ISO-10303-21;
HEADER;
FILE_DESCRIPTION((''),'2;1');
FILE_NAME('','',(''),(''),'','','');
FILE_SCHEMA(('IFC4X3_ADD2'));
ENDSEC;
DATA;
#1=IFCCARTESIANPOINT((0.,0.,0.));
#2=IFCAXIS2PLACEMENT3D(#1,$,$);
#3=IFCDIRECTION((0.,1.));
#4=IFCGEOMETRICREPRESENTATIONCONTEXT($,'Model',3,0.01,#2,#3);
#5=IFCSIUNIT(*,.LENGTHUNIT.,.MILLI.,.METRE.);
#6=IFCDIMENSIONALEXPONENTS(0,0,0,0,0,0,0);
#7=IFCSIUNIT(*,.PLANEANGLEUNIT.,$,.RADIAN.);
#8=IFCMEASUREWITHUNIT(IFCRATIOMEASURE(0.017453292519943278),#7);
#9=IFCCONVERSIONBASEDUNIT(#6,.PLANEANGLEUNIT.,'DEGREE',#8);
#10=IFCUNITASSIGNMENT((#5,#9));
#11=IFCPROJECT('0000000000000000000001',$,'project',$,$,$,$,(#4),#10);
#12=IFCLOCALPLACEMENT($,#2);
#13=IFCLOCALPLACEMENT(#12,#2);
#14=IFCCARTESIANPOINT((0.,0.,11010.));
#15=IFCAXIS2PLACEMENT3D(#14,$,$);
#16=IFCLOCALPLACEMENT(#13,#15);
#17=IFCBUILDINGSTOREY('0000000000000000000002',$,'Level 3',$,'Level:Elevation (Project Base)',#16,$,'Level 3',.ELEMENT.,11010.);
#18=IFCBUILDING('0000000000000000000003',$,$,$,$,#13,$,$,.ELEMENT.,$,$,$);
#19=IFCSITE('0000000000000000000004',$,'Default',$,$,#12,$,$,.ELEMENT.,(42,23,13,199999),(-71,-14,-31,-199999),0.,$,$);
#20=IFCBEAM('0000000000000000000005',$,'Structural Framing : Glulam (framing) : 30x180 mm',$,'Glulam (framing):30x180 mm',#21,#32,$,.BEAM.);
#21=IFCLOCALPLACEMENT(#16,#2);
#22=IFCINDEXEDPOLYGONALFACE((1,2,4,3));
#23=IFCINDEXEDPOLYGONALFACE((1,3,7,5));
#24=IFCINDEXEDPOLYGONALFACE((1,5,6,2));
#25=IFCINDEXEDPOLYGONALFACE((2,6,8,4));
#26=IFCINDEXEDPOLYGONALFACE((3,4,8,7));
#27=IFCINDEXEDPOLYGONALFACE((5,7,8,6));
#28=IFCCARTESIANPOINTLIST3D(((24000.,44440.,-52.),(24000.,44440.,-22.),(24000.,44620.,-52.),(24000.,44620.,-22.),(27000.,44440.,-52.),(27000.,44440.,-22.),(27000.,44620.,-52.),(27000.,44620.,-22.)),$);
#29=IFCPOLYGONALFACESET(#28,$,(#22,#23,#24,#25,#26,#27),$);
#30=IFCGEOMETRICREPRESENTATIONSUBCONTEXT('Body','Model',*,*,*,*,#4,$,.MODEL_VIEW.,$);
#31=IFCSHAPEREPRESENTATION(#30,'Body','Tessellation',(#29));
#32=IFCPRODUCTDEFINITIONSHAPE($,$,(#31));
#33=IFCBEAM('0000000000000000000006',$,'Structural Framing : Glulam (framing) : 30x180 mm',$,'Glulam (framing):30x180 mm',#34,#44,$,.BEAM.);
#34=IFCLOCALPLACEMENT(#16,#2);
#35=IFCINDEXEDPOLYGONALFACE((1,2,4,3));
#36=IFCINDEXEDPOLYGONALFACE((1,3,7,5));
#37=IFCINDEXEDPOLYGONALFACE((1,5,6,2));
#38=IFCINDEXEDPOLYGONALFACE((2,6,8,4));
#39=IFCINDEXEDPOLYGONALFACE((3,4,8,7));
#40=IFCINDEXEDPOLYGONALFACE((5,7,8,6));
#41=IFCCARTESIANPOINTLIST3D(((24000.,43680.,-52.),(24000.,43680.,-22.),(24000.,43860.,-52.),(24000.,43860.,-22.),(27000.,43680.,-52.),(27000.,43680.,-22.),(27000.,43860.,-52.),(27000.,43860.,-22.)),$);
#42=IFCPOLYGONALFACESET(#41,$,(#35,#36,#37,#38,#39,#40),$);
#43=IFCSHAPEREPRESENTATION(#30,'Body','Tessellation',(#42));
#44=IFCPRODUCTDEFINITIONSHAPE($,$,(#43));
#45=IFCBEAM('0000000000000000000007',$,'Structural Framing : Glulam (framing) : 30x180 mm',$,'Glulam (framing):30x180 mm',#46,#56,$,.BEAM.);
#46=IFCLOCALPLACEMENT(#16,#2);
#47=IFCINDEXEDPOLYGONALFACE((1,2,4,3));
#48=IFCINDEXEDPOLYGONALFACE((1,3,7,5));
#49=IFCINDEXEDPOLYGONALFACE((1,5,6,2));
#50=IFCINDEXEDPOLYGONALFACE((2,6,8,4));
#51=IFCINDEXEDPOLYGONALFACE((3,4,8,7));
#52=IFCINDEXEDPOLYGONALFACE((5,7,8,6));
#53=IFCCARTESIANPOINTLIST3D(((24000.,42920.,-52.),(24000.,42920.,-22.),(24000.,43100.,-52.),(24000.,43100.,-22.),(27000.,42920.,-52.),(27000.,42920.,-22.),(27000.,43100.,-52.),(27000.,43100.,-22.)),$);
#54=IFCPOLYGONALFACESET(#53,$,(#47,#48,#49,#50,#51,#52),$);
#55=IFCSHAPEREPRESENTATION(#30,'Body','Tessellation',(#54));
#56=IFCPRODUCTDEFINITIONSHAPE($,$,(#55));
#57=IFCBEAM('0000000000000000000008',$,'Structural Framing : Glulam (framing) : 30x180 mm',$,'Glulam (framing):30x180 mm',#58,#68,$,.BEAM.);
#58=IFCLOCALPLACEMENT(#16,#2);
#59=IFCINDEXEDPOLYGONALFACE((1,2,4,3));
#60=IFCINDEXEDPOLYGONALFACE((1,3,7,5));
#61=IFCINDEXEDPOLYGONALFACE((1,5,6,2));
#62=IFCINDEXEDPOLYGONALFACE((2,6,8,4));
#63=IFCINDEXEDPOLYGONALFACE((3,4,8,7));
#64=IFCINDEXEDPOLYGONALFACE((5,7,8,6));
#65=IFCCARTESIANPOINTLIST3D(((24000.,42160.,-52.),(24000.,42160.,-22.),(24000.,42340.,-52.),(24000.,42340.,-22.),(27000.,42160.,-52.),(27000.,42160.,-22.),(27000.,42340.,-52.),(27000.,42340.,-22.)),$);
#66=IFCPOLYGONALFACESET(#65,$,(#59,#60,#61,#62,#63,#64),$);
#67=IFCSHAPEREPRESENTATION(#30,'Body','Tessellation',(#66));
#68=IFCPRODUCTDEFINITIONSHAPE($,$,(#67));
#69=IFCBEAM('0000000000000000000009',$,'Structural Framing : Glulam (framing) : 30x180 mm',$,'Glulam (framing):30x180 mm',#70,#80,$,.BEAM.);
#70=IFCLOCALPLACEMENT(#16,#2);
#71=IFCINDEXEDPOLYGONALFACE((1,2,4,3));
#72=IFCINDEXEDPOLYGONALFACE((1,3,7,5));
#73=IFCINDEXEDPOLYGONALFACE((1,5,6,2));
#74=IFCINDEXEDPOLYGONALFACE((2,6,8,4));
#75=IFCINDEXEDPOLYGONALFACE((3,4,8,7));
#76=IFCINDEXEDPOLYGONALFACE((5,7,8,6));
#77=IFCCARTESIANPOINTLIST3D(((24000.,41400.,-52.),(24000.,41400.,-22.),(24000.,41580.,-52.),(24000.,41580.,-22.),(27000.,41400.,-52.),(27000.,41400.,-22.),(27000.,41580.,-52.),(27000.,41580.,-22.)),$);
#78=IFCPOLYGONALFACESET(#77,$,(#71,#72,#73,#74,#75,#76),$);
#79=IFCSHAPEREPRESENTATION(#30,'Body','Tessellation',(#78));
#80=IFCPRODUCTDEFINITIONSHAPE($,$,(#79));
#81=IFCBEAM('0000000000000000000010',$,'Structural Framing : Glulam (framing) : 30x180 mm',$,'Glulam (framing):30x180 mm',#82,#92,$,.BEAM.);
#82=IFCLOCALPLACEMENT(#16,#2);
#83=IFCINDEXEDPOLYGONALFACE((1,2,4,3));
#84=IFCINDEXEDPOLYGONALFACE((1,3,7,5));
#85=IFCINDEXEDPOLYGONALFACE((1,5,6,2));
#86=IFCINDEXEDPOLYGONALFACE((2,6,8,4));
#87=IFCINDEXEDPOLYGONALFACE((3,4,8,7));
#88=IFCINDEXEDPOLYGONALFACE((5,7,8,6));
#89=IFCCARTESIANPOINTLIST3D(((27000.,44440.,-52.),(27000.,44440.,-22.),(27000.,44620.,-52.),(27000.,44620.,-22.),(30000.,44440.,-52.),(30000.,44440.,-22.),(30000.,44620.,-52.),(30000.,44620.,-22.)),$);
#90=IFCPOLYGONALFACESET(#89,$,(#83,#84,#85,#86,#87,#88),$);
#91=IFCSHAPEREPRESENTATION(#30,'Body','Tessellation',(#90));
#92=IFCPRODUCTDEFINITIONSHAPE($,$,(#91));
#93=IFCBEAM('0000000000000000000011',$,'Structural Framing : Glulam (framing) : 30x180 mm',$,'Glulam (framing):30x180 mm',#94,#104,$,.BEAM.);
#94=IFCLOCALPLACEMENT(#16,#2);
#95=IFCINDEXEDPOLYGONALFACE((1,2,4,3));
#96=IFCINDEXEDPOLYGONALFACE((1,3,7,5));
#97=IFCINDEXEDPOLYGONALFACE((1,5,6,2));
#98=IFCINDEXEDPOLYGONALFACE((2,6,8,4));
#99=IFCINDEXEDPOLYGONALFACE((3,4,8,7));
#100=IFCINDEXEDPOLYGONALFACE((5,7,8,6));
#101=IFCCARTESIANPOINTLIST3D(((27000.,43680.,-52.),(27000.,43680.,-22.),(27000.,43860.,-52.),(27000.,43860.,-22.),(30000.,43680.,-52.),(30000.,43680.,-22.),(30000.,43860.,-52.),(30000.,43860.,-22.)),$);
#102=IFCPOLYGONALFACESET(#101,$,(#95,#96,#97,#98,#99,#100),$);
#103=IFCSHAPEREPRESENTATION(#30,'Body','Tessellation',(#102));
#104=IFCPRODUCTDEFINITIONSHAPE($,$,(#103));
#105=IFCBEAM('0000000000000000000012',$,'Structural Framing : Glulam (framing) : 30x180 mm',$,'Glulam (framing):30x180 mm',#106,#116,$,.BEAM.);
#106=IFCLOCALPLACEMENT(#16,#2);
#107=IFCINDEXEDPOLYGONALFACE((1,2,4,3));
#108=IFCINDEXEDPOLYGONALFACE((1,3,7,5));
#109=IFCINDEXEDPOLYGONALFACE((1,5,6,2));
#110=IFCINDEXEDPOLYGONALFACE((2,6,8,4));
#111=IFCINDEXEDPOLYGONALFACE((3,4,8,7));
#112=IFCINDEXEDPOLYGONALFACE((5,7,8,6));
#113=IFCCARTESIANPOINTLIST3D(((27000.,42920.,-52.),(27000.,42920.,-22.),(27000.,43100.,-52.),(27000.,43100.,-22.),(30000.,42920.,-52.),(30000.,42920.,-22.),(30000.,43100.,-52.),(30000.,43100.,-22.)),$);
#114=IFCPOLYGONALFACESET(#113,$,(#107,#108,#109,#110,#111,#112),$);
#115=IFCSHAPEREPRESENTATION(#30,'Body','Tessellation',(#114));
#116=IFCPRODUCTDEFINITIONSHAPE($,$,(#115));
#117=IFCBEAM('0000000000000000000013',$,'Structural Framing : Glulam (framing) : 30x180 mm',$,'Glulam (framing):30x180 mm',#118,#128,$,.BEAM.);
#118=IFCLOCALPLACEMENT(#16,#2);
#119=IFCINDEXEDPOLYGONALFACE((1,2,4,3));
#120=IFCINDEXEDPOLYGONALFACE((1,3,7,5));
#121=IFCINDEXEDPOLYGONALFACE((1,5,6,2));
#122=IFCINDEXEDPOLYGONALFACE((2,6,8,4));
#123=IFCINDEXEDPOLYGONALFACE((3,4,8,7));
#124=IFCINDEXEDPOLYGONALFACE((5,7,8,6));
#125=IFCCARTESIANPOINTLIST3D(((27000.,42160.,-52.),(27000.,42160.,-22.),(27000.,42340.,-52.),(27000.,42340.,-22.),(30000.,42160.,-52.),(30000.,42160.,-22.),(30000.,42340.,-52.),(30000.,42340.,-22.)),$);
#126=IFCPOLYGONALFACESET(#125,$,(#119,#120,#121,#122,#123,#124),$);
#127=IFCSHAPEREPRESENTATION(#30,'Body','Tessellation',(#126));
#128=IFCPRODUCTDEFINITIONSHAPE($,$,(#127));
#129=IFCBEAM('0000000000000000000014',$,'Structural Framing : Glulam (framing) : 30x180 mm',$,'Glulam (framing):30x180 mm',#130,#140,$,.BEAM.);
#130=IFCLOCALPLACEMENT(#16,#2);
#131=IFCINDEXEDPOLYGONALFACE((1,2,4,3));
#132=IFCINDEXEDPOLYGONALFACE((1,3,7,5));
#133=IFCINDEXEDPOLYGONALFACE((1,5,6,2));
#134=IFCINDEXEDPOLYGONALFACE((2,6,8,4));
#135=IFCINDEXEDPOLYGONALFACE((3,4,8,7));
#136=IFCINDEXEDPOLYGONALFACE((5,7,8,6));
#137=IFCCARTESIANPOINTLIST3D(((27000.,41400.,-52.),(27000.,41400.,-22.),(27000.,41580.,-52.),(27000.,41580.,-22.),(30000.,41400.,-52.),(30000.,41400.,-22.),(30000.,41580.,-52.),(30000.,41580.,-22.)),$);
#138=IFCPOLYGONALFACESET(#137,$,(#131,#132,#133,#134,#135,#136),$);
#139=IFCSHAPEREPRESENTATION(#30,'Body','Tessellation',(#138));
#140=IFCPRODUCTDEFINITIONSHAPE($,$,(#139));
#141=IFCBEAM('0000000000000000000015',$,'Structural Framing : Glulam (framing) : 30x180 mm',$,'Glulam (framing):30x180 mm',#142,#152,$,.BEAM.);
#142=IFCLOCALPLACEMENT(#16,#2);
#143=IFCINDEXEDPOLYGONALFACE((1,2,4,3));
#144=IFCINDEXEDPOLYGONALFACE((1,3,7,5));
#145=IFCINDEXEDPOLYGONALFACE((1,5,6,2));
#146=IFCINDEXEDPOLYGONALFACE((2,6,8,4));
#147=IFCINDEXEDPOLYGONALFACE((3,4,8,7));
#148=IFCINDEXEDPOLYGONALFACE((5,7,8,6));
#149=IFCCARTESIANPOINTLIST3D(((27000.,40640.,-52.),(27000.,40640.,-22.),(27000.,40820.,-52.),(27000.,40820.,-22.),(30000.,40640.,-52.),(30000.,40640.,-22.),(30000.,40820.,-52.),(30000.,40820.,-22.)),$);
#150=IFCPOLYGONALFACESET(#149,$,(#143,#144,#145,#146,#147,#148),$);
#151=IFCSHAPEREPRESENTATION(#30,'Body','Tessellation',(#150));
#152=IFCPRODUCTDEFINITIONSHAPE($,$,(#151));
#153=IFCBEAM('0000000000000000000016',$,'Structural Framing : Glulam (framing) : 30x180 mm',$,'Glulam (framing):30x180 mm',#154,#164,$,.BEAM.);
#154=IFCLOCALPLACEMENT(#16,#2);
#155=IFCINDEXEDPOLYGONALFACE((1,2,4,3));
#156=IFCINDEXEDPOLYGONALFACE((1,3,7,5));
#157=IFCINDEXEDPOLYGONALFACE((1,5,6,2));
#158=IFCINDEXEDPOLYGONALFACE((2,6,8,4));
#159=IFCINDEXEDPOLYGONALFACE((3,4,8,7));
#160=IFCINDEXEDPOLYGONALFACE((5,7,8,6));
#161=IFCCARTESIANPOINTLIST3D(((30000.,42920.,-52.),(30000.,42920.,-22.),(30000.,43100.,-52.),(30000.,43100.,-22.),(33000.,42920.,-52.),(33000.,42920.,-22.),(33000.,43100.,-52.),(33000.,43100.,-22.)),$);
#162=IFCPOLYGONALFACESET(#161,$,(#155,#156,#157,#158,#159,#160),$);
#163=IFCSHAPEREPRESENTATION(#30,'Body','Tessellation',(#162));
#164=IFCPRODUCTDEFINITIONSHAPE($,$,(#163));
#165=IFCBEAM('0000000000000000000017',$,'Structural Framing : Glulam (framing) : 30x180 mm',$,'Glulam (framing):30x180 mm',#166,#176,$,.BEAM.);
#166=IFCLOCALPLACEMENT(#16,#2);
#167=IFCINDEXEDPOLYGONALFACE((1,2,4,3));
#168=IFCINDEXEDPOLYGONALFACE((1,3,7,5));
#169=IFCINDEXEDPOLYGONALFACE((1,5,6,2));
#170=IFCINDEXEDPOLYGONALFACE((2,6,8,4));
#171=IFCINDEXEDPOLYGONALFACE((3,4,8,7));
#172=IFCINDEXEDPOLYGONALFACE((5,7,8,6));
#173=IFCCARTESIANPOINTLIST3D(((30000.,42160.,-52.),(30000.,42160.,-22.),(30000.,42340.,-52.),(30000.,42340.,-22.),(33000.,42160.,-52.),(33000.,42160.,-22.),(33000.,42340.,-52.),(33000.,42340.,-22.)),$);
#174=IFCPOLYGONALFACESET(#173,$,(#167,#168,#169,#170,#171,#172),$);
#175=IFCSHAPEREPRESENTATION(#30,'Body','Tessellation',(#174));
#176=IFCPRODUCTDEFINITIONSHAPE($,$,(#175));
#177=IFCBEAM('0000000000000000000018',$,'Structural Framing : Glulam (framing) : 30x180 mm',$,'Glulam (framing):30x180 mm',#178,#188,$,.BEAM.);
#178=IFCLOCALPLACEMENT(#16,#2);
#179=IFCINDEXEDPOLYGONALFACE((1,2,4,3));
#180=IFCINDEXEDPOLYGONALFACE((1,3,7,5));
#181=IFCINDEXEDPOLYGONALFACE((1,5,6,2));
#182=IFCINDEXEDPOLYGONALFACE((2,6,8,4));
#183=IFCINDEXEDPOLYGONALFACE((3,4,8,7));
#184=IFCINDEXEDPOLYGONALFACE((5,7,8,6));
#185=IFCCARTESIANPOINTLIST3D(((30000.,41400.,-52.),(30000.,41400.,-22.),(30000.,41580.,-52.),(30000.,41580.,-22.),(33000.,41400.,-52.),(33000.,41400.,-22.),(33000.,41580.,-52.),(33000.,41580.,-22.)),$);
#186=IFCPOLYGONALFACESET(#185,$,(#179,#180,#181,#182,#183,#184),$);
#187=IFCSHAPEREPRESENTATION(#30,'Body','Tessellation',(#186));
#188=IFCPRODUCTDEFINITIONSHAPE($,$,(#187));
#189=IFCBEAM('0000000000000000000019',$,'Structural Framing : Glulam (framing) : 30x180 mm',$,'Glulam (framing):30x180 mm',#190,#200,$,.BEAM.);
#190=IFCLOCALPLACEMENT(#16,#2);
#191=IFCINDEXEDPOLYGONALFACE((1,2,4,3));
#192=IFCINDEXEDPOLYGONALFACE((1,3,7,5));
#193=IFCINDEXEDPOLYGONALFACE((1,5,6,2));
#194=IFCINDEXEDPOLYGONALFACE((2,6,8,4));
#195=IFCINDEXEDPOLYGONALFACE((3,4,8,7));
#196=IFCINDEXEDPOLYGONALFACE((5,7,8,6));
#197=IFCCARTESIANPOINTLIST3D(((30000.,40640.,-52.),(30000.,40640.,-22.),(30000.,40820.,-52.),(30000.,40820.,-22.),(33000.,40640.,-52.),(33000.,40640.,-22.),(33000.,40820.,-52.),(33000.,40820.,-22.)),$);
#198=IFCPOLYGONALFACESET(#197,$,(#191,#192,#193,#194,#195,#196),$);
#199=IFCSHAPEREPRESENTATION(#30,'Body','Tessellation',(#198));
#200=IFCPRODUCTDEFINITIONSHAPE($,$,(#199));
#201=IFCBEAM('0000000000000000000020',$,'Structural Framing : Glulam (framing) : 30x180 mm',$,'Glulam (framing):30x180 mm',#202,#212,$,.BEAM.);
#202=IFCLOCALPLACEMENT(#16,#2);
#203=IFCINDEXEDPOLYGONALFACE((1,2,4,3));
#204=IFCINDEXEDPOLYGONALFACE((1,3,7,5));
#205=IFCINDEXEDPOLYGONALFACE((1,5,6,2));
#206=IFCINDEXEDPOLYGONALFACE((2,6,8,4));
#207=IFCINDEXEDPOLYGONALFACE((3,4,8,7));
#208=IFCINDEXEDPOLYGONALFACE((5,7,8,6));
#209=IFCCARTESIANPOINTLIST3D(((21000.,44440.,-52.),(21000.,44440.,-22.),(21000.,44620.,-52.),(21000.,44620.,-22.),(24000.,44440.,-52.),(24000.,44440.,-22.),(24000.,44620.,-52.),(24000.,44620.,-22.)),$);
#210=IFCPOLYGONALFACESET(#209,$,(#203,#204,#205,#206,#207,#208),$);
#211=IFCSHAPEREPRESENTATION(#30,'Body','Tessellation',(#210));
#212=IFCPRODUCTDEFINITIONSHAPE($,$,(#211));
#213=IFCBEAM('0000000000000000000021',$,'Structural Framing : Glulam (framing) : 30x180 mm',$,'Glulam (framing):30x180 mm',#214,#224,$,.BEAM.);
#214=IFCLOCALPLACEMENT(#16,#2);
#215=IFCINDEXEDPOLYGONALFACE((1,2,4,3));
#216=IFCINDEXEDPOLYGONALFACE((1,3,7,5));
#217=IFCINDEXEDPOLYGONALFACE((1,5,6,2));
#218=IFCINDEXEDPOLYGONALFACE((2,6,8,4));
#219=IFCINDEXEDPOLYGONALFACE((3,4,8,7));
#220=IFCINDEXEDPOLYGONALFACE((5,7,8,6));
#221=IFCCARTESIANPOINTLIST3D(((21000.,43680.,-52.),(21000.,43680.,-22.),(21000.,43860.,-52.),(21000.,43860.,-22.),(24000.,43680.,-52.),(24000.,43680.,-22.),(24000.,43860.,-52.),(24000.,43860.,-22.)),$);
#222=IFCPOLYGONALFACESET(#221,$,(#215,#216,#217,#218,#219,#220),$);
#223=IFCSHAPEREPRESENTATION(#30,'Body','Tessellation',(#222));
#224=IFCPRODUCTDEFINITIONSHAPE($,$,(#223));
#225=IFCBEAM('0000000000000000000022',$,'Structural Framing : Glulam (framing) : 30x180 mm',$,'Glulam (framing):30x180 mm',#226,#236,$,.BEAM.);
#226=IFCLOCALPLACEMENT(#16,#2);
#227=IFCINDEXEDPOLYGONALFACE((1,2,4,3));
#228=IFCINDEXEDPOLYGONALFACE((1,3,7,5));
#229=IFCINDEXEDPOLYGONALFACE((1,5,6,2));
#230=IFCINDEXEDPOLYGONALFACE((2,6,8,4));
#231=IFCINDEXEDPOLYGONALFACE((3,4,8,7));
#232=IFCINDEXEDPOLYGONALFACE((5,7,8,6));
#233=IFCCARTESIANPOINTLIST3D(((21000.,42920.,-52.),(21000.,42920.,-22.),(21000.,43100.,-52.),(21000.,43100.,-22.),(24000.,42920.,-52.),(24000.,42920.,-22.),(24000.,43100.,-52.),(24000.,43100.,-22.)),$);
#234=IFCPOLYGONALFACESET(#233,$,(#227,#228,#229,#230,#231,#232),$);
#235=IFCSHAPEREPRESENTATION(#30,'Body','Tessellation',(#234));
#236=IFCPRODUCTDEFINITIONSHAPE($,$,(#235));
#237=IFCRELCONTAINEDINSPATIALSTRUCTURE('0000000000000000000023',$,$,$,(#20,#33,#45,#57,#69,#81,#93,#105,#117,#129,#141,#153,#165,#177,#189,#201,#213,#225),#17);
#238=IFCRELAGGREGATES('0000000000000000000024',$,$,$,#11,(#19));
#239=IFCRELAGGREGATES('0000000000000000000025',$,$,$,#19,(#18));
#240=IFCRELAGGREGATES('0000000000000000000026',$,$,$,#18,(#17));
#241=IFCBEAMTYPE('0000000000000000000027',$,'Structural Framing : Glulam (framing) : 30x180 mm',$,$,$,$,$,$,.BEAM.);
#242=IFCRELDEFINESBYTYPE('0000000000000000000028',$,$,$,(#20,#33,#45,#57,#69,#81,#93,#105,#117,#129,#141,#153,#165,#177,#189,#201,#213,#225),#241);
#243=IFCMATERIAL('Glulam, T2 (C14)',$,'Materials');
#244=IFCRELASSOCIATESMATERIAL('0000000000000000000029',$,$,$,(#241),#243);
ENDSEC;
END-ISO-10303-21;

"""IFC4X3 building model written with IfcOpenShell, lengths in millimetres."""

from ifc_helpers import new_model, entity, si_unit, converted_unit, direction, frame, origin, origin_2d_with_axis, place, context, subcontext, project, spatial, rectangle, extrude, source, transform, mapped, material, material_profile, profile_set, type_object, type_shapes, element, save


model = new_model("IFC4X3")

# Units and contexts
model_context = context("Model", 3, precision=0.01, world=origin(), true_north=direction((0.0, 1.0)))
body_context = subcontext(model_context, "Body", "Model", "MODEL_VIEW")
ifc_project = project(units=[si_unit("LENGTHUNIT", "METRE", prefix="MILLI"), converted_unit("PLANEANGLEUNIT", "DEGREE", entity("IfcRatioMeasure", 0.017453292519943278), si_unit("PLANEANGLEUNIT", "RADIAN"), dimensions=[0, 0, 0, 0, 0, 0, 0])], contexts=[model_context])

# Site, building, storey
site_placement = place(None, origin())
site = spatial("IfcSite", under=ifc_project, at=site_placement, Name="Default", CompositionType="ELEMENT", RefLatitude=(42, 23, 13, 199999), RefLongitude=(-71, -14, -31, -199999), RefElevation=0.0)
building_placement = place(site_placement, origin())
building = spatial("IfcBuilding", under=site, at=building_placement, CompositionType="ELEMENT")
storey_placement = place(building_placement, frame((0.0, 0.0, 11010.0)))
storey = spatial("IfcBuildingStorey", under=building, at=storey_placement, Name="Level 3", ObjectType="Level:Elevation (Project Base)", LongName="Level 3", CompositionType="ELEMENT", Elevation=11010.0)

# Beams
ifc_material_1 = material(Name="Glulam, T2 (C14)", Category="Materials")
ifc_material_profile_1 = material_profile(ifc_material_1, rectangle(XDim=30.0, YDim=180.0, at=origin_2d_with_axis()), Name="30x180 mm")
ifc_profile_set_1 = profile_set([ifc_material_profile_1], Name="30x180 mm")
beam_type_1 = type_object("IfcBeamType", Name="Structural Framing : Glulam (framing) : 30x180 mm", PredefinedType="BEAM", material=ifc_profile_set_1)
shared_shape_1 = source(origin(), body_context, "Body", "SweptSolid", [
    extrude(rectangle(XDim=30.0, YDim=180.0, at=origin_2d_with_axis()), frame((500.0, 0.0, 0.0), z_axis=(1.0, 0.0, 0.0), x_axis=(0.0, 0.0, -1.0)), (0.0, 0.0, 1.0), 3000.0),
])
type_shapes(beam_type_1, [shared_shape_1])
for number, where, name in (
    (1, (23500.0, 44530.0, -37.0), "Structural Framing : Glulam (framing) : 30x180 mm"),
    (2, (23500.0, 43770.0, -37.0), "Structural Framing : Glulam (framing) : 30x180 mm"),
    (3, (23500.0, 43010.0, -37.0), "Structural Framing : Glulam (framing) : 30x180 mm"),
    (4, (23500.0, 42250.0, -37.0), "Structural Framing : Glulam (framing) : 30x180 mm"),
    (5, (23500.0, 41490.0, -37.0), "Structural Framing : Glulam (framing) : 30x180 mm"),
    (6, (26500.0, 44530.0, -37.0), "Structural Framing : Glulam (framing) : 30x180 mm"),
    (7, (26500.0, 43770.0, -37.0), "Structural Framing : Glulam (framing) : 30x180 mm"),
    (8, (26500.0, 43010.0, -37.0), "Structural Framing : Glulam (framing) : 30x180 mm"),
    (9, (26500.0, 42250.0, -37.0), "Structural Framing : Glulam (framing) : 30x180 mm"),
    (10, (26500.0, 41490.0, -37.0), "Structural Framing : Glulam (framing) : 30x180 mm"),
    (11, (26500.0, 40730.0, -37.0), "Structural Framing : Glulam (framing) : 30x180 mm"),
    (12, (29500.0, 43010.0, -37.0), "Structural Framing : Glulam (framing) : 30x180 mm"),
    (13, (29500.0, 42250.0, -37.0), "Structural Framing : Glulam (framing) : 30x180 mm"),
    (14, (29500.0, 41490.0, -37.0), "Structural Framing : Glulam (framing) : 30x180 mm"),
    (15, (29500.0, 40730.0, -37.0), "Structural Framing : Glulam (framing) : 30x180 mm"),
    (16, (20500.0, 44530.0, -37.0), "Structural Framing : Glulam (framing) : 30x180 mm"),
    (17, (20500.0, 43770.0, -37.0), "Structural Framing : Glulam (framing) : 30x180 mm"),
    (18, (20500.0, 43010.0, -37.0), "Structural Framing : Glulam (framing) : 30x180 mm"),
):
    element("IfcBeam", number, at=place(storey_placement, frame(where)), inside=storey, type_object=beam_type_1, Name=name, ObjectType="Glulam (framing):30x180 mm", PredefinedType="BEAM", context=body_context, shape_type="MappedRepresentation", body=[
        mapped(shared_shape_1, transform((0.0, 0.0, 0.0), scale=1.0)),
    ])

save(model, "model.ifc")
